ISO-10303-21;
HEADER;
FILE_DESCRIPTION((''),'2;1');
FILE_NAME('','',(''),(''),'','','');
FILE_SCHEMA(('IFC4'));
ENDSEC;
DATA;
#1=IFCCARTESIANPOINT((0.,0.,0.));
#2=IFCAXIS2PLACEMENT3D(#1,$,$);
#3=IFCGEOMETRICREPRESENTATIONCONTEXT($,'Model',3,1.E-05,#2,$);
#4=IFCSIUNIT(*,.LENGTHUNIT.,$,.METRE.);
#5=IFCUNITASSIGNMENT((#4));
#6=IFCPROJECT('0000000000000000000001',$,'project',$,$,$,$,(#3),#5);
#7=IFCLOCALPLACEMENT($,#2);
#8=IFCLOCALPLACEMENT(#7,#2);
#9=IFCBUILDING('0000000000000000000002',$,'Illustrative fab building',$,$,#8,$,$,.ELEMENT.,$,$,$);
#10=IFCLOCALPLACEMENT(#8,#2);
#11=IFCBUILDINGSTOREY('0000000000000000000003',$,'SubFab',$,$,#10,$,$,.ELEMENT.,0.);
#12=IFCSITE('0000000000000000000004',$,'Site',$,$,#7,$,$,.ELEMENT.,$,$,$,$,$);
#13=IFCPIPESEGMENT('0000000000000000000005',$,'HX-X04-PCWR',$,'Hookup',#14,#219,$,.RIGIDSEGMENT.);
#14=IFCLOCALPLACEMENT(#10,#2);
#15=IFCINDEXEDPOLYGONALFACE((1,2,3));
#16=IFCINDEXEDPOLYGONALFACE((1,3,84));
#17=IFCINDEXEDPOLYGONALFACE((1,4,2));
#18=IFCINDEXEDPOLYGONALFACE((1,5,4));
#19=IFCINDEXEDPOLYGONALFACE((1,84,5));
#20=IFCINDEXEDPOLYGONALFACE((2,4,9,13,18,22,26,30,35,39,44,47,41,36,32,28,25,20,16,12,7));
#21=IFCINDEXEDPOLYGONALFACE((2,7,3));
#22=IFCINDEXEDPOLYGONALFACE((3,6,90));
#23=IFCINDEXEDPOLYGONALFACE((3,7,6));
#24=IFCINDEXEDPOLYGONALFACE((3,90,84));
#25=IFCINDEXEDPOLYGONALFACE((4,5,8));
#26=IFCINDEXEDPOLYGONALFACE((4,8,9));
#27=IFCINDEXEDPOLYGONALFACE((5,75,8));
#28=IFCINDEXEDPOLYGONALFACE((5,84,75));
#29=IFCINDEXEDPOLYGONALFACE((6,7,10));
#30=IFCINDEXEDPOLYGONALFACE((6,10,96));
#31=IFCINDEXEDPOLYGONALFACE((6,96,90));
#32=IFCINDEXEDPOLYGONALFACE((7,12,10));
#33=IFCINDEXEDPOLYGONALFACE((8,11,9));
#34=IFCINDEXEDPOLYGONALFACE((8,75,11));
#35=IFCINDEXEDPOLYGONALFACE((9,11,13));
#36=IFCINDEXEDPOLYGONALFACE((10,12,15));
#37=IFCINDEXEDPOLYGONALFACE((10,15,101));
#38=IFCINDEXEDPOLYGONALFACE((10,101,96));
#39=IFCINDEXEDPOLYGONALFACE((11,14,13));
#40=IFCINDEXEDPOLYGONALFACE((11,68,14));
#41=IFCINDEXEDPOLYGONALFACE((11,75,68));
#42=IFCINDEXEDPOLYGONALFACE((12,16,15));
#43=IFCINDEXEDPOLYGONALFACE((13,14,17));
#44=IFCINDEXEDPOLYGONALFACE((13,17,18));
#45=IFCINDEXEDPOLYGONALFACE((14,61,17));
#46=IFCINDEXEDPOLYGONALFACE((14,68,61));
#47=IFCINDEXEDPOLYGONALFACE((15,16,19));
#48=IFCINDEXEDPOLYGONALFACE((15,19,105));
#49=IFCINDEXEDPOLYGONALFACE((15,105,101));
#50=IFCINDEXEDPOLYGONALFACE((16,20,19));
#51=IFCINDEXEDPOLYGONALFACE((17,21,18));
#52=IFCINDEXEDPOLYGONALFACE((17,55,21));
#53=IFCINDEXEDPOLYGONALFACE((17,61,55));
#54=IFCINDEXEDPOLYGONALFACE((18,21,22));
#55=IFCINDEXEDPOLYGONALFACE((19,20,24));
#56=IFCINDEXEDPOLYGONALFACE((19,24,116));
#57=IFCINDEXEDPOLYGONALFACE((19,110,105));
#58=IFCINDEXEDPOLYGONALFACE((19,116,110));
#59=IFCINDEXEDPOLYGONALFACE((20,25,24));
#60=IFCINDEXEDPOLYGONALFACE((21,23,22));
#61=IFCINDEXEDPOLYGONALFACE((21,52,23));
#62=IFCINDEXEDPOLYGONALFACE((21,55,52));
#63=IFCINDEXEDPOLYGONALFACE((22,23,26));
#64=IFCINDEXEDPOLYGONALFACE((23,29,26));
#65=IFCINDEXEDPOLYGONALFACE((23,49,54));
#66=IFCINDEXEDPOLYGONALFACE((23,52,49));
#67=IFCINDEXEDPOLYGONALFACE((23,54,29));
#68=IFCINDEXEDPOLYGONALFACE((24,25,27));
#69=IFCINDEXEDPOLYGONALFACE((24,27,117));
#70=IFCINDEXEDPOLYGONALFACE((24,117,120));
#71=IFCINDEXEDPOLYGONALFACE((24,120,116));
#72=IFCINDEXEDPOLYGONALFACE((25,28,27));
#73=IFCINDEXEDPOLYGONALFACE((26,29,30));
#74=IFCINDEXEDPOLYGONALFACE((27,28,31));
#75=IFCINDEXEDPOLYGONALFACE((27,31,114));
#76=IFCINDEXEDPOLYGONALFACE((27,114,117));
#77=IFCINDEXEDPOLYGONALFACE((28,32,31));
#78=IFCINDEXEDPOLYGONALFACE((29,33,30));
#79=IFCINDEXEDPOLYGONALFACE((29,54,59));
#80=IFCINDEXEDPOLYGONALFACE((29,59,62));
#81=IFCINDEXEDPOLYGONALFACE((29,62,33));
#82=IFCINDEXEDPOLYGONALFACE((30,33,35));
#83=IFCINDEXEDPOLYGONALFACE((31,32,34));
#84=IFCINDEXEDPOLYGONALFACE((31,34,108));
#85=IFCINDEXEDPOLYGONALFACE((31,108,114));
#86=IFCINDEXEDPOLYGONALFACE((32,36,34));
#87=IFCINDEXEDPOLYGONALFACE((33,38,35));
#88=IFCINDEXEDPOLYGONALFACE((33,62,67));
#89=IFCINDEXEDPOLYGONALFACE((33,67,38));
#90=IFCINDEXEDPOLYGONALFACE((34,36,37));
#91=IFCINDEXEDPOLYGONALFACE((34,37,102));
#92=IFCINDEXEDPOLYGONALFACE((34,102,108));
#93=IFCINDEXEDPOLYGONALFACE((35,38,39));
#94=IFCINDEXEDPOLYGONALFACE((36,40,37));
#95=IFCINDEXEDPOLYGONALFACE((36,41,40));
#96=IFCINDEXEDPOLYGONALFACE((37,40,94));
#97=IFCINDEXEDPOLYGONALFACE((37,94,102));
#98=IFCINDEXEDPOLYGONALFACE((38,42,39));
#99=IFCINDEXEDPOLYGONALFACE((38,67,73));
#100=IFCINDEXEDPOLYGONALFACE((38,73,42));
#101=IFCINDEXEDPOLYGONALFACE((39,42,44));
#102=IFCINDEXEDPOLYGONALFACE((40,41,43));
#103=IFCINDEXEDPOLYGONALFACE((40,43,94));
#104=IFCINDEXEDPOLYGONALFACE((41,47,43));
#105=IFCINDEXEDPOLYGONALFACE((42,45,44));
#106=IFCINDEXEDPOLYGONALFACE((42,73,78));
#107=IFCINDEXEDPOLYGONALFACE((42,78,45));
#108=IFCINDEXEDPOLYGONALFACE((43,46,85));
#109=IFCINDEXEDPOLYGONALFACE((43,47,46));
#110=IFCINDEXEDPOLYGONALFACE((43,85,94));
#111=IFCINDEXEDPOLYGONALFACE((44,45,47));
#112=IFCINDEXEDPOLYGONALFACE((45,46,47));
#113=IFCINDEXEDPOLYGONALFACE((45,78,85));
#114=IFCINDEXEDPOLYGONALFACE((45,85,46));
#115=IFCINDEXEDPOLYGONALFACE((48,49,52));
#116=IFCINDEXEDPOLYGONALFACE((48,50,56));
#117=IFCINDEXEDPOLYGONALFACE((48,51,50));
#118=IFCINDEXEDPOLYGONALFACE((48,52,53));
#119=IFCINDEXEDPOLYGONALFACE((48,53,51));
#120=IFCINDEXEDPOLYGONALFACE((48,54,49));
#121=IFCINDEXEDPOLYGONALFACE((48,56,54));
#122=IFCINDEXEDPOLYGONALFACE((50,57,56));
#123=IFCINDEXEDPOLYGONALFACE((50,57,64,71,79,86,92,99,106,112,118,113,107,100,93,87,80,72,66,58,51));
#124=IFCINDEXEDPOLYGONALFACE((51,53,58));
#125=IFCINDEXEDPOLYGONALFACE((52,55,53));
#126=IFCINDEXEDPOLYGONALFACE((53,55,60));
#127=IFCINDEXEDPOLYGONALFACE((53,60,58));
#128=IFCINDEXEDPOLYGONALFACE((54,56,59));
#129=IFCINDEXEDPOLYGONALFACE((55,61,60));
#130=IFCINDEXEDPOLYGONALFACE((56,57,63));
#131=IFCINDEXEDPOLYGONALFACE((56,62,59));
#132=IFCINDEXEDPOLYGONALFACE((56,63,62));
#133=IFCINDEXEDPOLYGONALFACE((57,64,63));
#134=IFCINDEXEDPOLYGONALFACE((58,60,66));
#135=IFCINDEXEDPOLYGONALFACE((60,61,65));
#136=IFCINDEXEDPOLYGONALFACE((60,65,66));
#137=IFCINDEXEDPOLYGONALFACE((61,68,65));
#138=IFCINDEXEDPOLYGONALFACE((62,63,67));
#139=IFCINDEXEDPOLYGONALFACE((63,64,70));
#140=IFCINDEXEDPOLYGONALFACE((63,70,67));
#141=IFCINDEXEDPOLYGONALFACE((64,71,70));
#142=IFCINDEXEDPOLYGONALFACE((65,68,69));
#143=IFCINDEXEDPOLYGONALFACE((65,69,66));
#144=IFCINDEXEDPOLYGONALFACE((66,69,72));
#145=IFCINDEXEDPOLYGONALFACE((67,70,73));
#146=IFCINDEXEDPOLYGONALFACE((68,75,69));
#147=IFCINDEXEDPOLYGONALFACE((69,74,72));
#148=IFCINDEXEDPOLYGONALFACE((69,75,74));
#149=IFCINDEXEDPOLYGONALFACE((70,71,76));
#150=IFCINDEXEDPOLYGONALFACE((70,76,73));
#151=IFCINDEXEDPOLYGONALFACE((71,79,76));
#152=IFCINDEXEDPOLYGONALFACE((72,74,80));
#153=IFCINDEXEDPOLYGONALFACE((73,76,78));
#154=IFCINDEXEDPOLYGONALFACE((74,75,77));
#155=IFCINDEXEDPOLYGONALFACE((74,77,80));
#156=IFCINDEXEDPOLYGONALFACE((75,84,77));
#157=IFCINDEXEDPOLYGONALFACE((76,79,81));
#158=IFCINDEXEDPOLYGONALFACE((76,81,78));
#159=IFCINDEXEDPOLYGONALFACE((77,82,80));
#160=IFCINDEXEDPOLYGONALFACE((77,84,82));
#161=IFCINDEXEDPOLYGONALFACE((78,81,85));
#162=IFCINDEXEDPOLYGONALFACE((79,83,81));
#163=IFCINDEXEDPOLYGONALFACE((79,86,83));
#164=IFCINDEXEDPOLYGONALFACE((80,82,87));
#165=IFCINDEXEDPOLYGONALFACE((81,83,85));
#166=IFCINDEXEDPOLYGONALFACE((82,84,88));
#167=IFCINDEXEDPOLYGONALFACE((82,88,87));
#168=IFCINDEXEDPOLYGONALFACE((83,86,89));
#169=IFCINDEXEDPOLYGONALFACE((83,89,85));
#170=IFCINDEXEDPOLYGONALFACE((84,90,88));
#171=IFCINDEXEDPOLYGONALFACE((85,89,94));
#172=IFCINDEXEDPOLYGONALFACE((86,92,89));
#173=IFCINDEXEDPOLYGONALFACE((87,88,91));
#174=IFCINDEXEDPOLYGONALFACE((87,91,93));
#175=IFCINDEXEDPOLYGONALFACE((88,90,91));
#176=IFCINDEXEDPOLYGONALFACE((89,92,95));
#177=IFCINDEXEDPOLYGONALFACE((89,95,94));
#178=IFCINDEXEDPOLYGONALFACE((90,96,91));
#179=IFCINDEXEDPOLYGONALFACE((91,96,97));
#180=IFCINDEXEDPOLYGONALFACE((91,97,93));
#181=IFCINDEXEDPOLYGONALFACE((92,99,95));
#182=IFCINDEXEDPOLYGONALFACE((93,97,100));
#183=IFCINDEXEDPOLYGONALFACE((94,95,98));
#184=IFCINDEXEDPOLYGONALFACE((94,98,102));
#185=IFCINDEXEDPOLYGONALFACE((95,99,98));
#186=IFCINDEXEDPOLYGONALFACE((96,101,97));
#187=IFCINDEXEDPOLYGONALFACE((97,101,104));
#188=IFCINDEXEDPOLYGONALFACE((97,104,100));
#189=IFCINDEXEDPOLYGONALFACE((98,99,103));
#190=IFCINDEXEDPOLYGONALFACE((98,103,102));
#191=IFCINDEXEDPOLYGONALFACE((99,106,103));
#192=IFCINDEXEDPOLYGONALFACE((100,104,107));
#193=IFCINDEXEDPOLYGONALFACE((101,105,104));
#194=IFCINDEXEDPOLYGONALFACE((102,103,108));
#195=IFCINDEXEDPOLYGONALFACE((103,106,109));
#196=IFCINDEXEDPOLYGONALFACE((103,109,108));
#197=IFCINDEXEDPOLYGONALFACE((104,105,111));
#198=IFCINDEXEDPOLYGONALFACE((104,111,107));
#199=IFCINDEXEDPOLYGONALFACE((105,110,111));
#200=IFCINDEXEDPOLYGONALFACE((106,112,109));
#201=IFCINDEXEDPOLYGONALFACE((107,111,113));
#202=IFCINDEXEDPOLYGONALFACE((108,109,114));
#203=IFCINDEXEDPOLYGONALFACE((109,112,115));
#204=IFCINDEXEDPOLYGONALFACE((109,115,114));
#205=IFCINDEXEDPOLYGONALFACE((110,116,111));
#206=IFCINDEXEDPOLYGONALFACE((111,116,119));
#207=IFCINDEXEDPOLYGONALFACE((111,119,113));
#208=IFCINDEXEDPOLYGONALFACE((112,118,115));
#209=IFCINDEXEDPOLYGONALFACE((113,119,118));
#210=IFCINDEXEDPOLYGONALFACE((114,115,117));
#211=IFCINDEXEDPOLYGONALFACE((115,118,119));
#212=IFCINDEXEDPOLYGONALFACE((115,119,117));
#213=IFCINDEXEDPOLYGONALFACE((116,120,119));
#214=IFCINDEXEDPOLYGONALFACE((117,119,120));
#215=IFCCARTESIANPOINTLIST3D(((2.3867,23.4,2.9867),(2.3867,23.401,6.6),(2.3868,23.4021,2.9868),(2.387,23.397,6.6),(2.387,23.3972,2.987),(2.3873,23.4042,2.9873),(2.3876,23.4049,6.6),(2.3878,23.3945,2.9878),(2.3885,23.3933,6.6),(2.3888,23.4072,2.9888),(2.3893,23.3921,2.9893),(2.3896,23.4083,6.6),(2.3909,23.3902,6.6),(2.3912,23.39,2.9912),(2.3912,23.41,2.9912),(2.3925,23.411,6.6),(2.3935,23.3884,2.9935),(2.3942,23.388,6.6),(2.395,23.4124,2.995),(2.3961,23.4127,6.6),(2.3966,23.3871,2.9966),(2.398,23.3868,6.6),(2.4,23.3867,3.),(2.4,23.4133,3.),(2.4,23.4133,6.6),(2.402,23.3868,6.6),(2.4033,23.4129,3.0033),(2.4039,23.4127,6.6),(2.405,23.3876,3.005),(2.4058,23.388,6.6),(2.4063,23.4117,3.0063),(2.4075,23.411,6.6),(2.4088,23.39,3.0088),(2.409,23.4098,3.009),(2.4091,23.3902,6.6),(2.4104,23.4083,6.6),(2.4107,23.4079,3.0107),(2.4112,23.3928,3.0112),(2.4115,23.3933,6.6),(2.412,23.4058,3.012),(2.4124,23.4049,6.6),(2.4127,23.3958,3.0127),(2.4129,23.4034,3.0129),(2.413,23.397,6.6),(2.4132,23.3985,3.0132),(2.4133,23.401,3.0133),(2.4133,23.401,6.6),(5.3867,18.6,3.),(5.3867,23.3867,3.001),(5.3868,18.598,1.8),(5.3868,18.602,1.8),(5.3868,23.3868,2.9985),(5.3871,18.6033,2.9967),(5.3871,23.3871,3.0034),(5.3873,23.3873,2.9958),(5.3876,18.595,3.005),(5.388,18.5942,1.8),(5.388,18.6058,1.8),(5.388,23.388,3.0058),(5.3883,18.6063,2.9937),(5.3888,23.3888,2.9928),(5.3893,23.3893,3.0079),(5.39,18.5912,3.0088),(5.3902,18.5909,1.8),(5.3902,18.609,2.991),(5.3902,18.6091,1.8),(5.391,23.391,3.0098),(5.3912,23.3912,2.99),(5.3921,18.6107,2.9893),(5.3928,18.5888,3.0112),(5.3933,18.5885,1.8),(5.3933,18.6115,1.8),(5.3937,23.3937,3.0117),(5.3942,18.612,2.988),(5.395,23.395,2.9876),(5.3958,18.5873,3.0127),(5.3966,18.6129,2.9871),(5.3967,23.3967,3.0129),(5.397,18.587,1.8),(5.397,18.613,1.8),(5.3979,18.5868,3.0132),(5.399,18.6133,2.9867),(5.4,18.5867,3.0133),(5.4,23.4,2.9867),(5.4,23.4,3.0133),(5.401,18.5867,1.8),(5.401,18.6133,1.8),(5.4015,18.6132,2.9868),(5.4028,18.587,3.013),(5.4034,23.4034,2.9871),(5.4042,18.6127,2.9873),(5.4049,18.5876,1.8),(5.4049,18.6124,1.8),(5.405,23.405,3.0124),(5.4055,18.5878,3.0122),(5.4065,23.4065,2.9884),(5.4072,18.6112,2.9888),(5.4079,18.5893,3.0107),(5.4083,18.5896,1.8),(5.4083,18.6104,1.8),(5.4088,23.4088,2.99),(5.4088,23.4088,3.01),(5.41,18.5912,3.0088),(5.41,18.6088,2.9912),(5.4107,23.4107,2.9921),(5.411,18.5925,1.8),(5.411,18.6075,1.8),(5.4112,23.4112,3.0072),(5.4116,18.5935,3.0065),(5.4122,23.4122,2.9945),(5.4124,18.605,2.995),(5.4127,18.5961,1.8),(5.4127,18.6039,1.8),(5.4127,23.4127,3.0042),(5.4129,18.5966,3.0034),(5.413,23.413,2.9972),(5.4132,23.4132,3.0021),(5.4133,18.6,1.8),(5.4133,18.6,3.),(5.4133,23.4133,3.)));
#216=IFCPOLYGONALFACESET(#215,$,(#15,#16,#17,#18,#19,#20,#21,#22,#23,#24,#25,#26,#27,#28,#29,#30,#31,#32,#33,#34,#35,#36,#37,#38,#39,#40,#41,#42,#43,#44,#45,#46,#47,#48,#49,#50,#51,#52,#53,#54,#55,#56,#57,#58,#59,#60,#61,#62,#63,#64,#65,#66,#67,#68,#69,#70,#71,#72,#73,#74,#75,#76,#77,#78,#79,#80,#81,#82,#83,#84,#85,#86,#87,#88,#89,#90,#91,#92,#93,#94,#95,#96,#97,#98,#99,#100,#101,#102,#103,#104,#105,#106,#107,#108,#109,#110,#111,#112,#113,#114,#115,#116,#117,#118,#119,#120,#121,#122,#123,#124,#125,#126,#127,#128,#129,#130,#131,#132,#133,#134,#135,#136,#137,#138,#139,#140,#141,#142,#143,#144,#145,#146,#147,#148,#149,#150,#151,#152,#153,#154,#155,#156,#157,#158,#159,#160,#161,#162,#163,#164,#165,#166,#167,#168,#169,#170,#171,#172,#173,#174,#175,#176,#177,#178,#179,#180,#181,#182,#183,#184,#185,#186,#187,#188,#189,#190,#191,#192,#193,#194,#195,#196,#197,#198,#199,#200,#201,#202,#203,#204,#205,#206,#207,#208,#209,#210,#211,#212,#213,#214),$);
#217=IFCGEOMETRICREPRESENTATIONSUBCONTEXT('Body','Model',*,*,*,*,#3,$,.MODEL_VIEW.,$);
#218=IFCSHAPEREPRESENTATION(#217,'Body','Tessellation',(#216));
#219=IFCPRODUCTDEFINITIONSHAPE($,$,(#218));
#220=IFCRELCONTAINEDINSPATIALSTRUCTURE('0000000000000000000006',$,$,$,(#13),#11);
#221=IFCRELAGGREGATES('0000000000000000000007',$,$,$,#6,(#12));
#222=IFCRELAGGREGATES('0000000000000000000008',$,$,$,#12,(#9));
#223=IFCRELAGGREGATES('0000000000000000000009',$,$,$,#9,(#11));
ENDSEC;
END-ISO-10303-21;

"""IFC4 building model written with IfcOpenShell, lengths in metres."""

from ifc_helpers import new_model, entity, si_unit, origin, place, context, subcontext, project, spatial, element, save


model = new_model("IFC4")

# Units and contexts
model_context = context("Model", 3, precision=1e-05, world=origin())
body_context = subcontext(model_context, "Body", "Model", "MODEL_VIEW")
ifc_project = project(units=[si_unit("LENGTHUNIT", "METRE")], contexts=[model_context])

# Site, building, storey
site_placement = place(None, origin())
site = spatial("IfcSite", under=ifc_project, at=site_placement, Name="Site", CompositionType="ELEMENT")
building_placement = place(site_placement, origin())
building = spatial("IfcBuilding", under=site, at=building_placement, Name="Illustrative fab building", CompositionType="ELEMENT")
storey_placement = place(building_placement, origin())
storey = spatial("IfcBuildingStorey", under=building, at=storey_placement, Name="SubFab", CompositionType="ELEMENT", Elevation=0.0)

# Pipe segment
pipe_segment_1_placement = place(storey_placement, origin())
element("IfcPipeSegment", 1, at=pipe_segment_1_placement, inside=storey, Name="HX-X04-PCWR", ObjectType="Hookup", PredefinedType="RIGIDSEGMENT", context=body_context, shape_type="AdvancedSweptSolid", body=[
    entity("IfcSweptDiskSolid", entity("IfcPolyline", [entity("IfcCartesianPoint", [5.4, 18.6, 1.8]), entity("IfcCartesianPoint", [5.4, 18.6, 3.0]), entity("IfcCartesianPoint", [5.4, 23.4, 3.0]), entity("IfcCartesianPoint", [2.4, 23.4, 3.0]), entity("IfcCartesianPoint", [2.4, 23.4, 6.6])]), 0.0133),
])

save(model, "model.ifc")
